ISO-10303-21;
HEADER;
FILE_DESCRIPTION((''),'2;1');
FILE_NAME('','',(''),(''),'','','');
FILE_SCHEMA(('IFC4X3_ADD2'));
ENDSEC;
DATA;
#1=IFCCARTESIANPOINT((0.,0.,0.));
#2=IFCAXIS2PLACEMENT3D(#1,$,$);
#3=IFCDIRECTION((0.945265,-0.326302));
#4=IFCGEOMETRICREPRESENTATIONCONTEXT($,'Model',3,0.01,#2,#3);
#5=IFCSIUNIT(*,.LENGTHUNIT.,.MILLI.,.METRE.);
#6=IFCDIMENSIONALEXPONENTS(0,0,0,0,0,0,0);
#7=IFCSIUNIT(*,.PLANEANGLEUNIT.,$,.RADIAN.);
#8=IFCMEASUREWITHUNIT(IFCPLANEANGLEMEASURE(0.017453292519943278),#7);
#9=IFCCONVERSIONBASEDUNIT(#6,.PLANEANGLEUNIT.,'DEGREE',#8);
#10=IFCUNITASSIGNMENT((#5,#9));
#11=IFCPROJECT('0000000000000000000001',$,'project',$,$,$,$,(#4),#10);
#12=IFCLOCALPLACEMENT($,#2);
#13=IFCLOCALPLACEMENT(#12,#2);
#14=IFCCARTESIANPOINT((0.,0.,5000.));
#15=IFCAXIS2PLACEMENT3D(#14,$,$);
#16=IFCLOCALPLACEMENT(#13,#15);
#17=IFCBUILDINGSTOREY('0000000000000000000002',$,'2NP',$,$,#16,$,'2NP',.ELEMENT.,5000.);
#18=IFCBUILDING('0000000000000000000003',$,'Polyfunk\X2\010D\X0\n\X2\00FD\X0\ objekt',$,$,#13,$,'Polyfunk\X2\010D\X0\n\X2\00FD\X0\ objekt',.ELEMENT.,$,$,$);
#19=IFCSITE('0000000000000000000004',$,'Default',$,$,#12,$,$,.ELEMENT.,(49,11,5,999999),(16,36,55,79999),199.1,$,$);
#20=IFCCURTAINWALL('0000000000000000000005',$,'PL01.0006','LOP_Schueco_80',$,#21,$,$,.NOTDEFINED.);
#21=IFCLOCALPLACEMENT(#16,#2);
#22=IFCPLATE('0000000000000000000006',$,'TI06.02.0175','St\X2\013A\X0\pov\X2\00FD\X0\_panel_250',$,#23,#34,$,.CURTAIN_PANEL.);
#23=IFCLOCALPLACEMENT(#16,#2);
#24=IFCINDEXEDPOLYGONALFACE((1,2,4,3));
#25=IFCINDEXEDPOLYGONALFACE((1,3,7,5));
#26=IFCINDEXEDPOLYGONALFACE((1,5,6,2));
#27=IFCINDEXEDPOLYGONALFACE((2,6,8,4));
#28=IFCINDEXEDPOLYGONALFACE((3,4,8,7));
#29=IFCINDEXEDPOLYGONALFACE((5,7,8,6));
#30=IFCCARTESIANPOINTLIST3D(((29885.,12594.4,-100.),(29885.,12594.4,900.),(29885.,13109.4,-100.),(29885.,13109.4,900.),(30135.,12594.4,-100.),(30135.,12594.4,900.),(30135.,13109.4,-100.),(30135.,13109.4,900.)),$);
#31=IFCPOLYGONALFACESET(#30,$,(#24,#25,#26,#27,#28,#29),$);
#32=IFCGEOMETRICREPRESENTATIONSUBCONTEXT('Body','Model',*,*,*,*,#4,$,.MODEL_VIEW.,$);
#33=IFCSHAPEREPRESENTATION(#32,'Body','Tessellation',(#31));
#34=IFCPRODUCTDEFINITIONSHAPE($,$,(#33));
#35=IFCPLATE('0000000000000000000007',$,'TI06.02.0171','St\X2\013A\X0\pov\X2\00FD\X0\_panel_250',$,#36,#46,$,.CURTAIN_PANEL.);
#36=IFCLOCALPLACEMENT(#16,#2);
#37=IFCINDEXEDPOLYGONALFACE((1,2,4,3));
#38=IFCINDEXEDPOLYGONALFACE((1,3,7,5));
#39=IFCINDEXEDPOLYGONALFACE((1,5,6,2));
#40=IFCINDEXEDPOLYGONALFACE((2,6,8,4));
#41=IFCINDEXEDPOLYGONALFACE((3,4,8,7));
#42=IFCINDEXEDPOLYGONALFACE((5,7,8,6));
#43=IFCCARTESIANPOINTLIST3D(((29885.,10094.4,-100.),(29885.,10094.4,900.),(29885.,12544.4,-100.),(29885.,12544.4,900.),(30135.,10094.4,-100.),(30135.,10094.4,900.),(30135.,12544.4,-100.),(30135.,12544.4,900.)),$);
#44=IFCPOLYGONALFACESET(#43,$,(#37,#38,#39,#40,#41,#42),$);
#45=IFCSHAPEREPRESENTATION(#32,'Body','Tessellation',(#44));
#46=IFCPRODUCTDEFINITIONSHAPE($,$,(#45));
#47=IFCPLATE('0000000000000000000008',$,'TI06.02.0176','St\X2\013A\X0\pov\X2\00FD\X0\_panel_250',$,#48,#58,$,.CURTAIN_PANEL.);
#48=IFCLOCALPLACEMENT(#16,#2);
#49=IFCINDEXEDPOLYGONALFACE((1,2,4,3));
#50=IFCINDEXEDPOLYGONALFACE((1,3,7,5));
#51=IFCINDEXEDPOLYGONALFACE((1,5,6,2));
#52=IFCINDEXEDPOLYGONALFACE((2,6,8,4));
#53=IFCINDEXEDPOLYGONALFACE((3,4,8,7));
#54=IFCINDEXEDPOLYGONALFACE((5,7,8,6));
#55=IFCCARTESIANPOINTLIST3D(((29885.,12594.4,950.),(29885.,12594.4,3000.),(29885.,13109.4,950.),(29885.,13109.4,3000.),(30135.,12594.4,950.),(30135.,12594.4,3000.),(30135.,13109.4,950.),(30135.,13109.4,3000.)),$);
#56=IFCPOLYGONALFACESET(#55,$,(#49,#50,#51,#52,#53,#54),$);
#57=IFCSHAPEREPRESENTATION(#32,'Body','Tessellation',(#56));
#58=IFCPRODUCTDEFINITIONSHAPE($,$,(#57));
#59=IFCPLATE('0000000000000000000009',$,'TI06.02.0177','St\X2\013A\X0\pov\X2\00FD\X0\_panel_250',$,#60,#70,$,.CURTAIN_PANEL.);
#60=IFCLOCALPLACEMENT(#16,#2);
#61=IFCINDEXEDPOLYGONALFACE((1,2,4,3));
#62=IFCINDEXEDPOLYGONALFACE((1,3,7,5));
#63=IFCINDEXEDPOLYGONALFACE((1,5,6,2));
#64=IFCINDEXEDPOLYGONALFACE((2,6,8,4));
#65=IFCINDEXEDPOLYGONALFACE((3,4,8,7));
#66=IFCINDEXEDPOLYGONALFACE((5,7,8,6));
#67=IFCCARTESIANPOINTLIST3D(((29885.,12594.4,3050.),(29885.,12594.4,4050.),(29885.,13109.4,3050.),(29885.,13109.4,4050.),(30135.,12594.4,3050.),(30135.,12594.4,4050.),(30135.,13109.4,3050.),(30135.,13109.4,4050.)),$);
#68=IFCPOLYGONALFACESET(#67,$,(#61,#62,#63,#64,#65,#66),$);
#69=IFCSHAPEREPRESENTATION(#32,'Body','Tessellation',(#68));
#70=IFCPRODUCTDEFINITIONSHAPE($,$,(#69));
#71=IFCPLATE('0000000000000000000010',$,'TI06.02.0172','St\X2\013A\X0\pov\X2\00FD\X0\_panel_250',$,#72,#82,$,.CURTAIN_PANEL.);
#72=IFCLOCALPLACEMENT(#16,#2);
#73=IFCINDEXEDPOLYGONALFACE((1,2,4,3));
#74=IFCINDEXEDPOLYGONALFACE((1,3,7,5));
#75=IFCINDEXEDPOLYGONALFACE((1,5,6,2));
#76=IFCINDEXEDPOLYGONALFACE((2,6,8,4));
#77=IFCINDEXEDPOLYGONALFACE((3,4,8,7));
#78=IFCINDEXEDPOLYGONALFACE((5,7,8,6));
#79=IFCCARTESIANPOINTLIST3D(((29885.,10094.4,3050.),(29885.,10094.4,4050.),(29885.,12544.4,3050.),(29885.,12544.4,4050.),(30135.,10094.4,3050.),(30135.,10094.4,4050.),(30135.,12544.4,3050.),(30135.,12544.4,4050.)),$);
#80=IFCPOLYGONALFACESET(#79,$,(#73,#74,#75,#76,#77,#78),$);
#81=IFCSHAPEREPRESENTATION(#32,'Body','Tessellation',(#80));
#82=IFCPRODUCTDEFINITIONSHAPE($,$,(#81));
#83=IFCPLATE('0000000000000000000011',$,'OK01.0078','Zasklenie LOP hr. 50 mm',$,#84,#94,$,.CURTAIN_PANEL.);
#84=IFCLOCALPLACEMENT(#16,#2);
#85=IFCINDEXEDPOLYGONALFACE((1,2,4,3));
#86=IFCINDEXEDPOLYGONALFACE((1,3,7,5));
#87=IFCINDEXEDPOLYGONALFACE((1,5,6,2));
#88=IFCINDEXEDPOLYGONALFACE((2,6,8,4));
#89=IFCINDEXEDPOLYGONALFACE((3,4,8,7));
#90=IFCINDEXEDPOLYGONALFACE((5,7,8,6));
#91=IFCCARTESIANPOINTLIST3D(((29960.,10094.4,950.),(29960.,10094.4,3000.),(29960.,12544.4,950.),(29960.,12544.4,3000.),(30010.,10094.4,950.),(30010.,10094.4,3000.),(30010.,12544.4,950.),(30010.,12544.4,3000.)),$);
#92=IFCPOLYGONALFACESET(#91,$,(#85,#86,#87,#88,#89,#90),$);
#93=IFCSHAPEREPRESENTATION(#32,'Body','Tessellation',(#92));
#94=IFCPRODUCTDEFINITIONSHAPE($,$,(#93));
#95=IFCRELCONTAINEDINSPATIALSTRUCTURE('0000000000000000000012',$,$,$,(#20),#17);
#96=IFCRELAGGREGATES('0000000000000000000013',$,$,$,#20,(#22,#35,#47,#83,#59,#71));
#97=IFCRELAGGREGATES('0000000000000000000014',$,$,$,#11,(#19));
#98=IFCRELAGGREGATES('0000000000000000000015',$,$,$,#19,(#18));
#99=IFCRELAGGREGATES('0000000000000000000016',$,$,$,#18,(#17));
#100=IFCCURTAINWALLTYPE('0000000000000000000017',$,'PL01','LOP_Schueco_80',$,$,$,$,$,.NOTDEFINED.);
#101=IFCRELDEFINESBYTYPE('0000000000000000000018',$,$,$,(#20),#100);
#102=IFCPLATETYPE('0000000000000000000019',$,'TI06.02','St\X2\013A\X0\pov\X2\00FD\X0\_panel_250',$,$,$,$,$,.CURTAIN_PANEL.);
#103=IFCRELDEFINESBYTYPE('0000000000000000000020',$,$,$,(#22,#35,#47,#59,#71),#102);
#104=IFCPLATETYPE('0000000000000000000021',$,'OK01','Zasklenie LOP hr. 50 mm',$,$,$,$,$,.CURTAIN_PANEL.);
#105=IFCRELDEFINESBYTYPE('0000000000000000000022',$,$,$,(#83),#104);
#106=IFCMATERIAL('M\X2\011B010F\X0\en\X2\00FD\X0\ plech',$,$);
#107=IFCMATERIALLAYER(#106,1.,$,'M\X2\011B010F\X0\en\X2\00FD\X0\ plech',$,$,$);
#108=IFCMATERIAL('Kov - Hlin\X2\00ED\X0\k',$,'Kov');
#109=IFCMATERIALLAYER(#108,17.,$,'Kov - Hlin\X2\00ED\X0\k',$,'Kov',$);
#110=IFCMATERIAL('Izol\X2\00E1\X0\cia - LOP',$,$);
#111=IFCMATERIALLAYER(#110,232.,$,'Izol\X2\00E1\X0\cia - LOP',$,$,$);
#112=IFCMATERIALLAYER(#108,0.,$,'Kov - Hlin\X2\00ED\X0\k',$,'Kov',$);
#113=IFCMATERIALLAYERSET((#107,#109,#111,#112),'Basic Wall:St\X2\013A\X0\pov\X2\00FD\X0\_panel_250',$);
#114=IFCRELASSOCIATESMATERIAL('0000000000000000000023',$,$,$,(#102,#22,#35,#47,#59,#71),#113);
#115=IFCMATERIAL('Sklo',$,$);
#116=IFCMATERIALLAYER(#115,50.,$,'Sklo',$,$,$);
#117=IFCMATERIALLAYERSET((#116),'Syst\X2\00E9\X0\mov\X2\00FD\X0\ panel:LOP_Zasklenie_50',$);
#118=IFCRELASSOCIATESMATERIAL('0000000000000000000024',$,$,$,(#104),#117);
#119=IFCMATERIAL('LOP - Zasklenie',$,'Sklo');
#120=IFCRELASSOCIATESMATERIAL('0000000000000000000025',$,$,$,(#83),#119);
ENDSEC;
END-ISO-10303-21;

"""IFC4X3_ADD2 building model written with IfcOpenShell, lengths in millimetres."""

from ifc_helpers import new_model, entity, si_unit, converted_unit, direction, frame, frame_2d, origin, origin_2d_with_axis, place, context, subcontext, project, spatial, rectangle, extrude, source, transform, mapped, material, layer, layer_set, layer_usage, type_object, type_shapes, element, aggregate, save


model = new_model("IFC4X3_ADD2")

# Units and contexts
model_context = context("Model", 3, precision=0.01, world=origin(), true_north=direction((0.945265, -0.326302)))
body_context = subcontext(model_context, "Body", "Model", "MODEL_VIEW")
ifc_project = project(units=[si_unit("LENGTHUNIT", "METRE", prefix="MILLI"), converted_unit("PLANEANGLEUNIT", "DEGREE", entity("IfcPlaneAngleMeasure", 0.017453292519943278), si_unit("PLANEANGLEUNIT", "RADIAN"), dimensions=[0, 0, 0, 0, 0, 0, 0])], contexts=[model_context])

# Site, building, storey
site_placement = place(None, origin())
site = spatial("IfcSite", under=ifc_project, at=site_placement, Name="Default", CompositionType="ELEMENT", RefLatitude=(49, 11, 5, 999999), RefLongitude=(16, 36, 55, 79999), RefElevation=199.1)
building_placement = place(site_placement, origin())
building = spatial("IfcBuilding", under=site, at=building_placement, Name="Polyfunkčný objekt", LongName="Polyfunkčný objekt", CompositionType="ELEMENT")
storey_placement = place(building_placement, frame((0.0, 0.0, 5000.0)))
storey = spatial("IfcBuildingStorey", under=building, at=storey_placement, Name="2NP", LongName="2NP", CompositionType="ELEMENT", Elevation=5000.0)

# Curtain wall
curtain_wall_type = type_object("IfcCurtainWallType", Name="PL01", Description="LOP_Schueco_80", PredefinedType="NOTDEFINED")
curtain_wall_1_placement = place(storey_placement, frame((0.0, 0.0, -5000.0)))
curtain_wall_1 = element("IfcCurtainWall", 1, at=curtain_wall_1_placement, inside=storey, type_object=curtain_wall_type, Name="PL01.0006", Description="LOP_Schueco_80", PredefinedType="NOTDEFINED")

# Plates
ifc_material_1 = material(Name="Měďený plech")
ifc_layer_1 = layer(ifc_material_1, 1.0, Name="Měďený plech")
ifc_material_2 = material(Name="Kov - Hliník", Category="Kov")
ifc_layer_2 = layer(ifc_material_2, 17.0, Name="Kov - Hliník", Category="Kov")
ifc_material_3 = material(Name="Izolácia - LOP")
ifc_layer_3 = layer(ifc_material_3, 232.0, Name="Izolácia - LOP")
ifc_layer_4 = layer(ifc_material_2, 0.0, Name="Kov - Hliník", Category="Kov")
ifc_layer_set_1 = layer_set([ifc_layer_1, ifc_layer_2, ifc_layer_3, ifc_layer_4], Name="Basic Wall:Stĺpový_panel_250")
ifc_layer_usage_1 = layer_usage(ifc_layer_set_1, "AXIS2", "POSITIVE", -125.0)
plate_type_1 = type_object("IfcPlateType", Name="TI06.02", Description="Stĺpový_panel_250", PredefinedType="CURTAIN_PANEL", material=ifc_layer_set_1)
plate_1_placement = place(storey_placement, frame((30010.0, 13109.4, -100.0), z_axis=(0.0, 0.0, 1.0), x_axis=(0.0, -1.0, 0.0)))
plate_1 = element("IfcPlate", 2, at=plate_1_placement, type_object=plate_type_1, material=ifc_layer_usage_1, Name="TI06.02.0175", Description="Stĺpový_panel_250", PredefinedType="CURTAIN_PANEL", context=body_context, shape_type="SweptSolid", body=[
    extrude(rectangle(XDim=250.0, YDim=515.0, at=frame_2d((0.0, 0.0), x_axis=(1.0, 0.0))), frame((257.5, 0.0, 0.0), z_axis=(0.0, 0.0, 1.0), x_axis=(0.0, 1.0, 0.0)), (0.0, 0.0, 1.0), 1000.0),
])
ifc_layer_usage_2 = layer_usage(ifc_layer_set_1, "AXIS2", "POSITIVE", -125.0)
plate_2_placement = place(storey_placement, frame((30010.0, 12544.4, -100.0), z_axis=(0.0, 0.0, 1.0), x_axis=(0.0, -1.0, 0.0)))
plate_2 = element("IfcPlate", 3, at=plate_2_placement, type_object=plate_type_1, material=ifc_layer_usage_2, Name="TI06.02.0171", Description="Stĺpový_panel_250", PredefinedType="CURTAIN_PANEL", context=body_context, shape_type="SweptSolid", body=[
    extrude(rectangle(XDim=250.0, YDim=2450.0, at=frame_2d((0.0, 0.0), x_axis=(1.0, 0.0))), frame((1225.0, 0.0, 0.0), z_axis=(0.0, 0.0, 1.0), x_axis=(0.0, 1.0, 0.0)), (0.0, 0.0, 1.0), 1000.0),
])
ifc_layer_usage_3 = layer_usage(ifc_layer_set_1, "AXIS2", "POSITIVE", -125.0)
plate_3_placement = place(storey_placement, frame((30010.0, 13109.4, 950.0), z_axis=(0.0, 0.0, 1.0), x_axis=(0.0, -1.0, 0.0)))
plate_3 = element("IfcPlate", 4, at=plate_3_placement, type_object=plate_type_1, material=ifc_layer_usage_3, Name="TI06.02.0176", Description="Stĺpový_panel_250", PredefinedType="CURTAIN_PANEL", context=body_context, shape_type="SweptSolid", body=[
    extrude(rectangle(XDim=250.0, YDim=515.0, at=frame_2d((0.0, 0.0), x_axis=(1.0, 0.0))), frame((257.5, 0.0, 0.0), z_axis=(0.0, 0.0, 1.0), x_axis=(0.0, 1.0, 0.0)), (0.0, 0.0, 1.0), 2050.0),
])
ifc_layer_usage_4 = layer_usage(ifc_layer_set_1, "AXIS2", "POSITIVE", -125.0)
plate_4_placement = place(storey_placement, frame((30010.0, 13109.4, 3050.0), z_axis=(0.0, 0.0, 1.0), x_axis=(0.0, -1.0, 0.0)))
plate_4 = element("IfcPlate", 5, at=plate_4_placement, type_object=plate_type_1, material=ifc_layer_usage_4, Name="TI06.02.0177", Description="Stĺpový_panel_250", PredefinedType="CURTAIN_PANEL", context=body_context, shape_type="SweptSolid", body=[
    extrude(rectangle(XDim=250.0, YDim=515.0, at=frame_2d((0.0, 0.0), x_axis=(1.0, 0.0))), frame((257.5, 0.0, 0.0), z_axis=(0.0, 0.0, 1.0), x_axis=(0.0, 1.0, 0.0)), (0.0, 0.0, 1.0), 1000.0),
])
ifc_layer_usage_5 = layer_usage(ifc_layer_set_1, "AXIS2", "POSITIVE", -125.0)
plate_5_placement = place(storey_placement, frame((30010.0, 12544.4, 3050.0), z_axis=(0.0, 0.0, 1.0), x_axis=(0.0, -1.0, 0.0)))
plate_5 = element("IfcPlate", 6, at=plate_5_placement, type_object=plate_type_1, material=ifc_layer_usage_5, Name="TI06.02.0172", Description="Stĺpový_panel_250", PredefinedType="CURTAIN_PANEL", context=body_context, shape_type="SweptSolid", body=[
    extrude(rectangle(XDim=250.0, YDim=2450.0, at=frame_2d((0.0, 0.0), x_axis=(1.0, 0.0))), frame((1225.0, 0.0, 0.0), z_axis=(0.0, 0.0, 1.0), x_axis=(0.0, 1.0, 0.0)), (0.0, 0.0, 1.0), 1000.0),
])
ifc_material_4 = material(Name="LOP - Zasklenie", Category="Sklo")
ifc_material_5 = material(Name="Sklo")
ifc_layer_5 = layer(ifc_material_5, 50.0, Name="Sklo")
ifc_layer_set_2 = layer_set([ifc_layer_5], Name="Systémový panel:LOP_Zasklenie_50")
plate_type_2 = type_object("IfcPlateType", Name="OK01", Description="Zasklenie LOP hr. 50 mm", PredefinedType="CURTAIN_PANEL", material=ifc_layer_set_2)
shared_shape_1 = source(origin(), body_context, "Body", "SweptSolid", [
    extrude(rectangle(XDim=50.0, YDim=2450.0, at=origin_2d_with_axis()), frame((0.0, -25.0, 0.0), z_axis=(0.0, 0.0, 1.0), x_axis=(0.0, 1.0, 0.0)), (0.0, 0.0, 1.0), 2050.0),
])
type_shapes(plate_type_2, [shared_shape_1])
plate_6_placement = place(curtain_wall_1_placement, frame((30010.0, 11319.4, 5950.0), z_axis=(0.0, 0.0, 1.0), x_axis=(0.0, -1.0, 0.0)))
plate_6 = element("IfcPlate", 7, at=plate_6_placement, type_object=plate_type_2, material=ifc_material_4, Name="OK01.0078", Description="Zasklenie LOP hr. 50 mm", PredefinedType="CURTAIN_PANEL", context=body_context, shape_type="MappedRepresentation", body=[
    mapped(shared_shape_1, transform((0.0, 0.0, 0.0), scale=1.0)),
])
aggregate(curtain_wall_1, [plate_1, plate_2, plate_3, plate_6, plate_4, plate_5])

save(model, "model.ifc")
